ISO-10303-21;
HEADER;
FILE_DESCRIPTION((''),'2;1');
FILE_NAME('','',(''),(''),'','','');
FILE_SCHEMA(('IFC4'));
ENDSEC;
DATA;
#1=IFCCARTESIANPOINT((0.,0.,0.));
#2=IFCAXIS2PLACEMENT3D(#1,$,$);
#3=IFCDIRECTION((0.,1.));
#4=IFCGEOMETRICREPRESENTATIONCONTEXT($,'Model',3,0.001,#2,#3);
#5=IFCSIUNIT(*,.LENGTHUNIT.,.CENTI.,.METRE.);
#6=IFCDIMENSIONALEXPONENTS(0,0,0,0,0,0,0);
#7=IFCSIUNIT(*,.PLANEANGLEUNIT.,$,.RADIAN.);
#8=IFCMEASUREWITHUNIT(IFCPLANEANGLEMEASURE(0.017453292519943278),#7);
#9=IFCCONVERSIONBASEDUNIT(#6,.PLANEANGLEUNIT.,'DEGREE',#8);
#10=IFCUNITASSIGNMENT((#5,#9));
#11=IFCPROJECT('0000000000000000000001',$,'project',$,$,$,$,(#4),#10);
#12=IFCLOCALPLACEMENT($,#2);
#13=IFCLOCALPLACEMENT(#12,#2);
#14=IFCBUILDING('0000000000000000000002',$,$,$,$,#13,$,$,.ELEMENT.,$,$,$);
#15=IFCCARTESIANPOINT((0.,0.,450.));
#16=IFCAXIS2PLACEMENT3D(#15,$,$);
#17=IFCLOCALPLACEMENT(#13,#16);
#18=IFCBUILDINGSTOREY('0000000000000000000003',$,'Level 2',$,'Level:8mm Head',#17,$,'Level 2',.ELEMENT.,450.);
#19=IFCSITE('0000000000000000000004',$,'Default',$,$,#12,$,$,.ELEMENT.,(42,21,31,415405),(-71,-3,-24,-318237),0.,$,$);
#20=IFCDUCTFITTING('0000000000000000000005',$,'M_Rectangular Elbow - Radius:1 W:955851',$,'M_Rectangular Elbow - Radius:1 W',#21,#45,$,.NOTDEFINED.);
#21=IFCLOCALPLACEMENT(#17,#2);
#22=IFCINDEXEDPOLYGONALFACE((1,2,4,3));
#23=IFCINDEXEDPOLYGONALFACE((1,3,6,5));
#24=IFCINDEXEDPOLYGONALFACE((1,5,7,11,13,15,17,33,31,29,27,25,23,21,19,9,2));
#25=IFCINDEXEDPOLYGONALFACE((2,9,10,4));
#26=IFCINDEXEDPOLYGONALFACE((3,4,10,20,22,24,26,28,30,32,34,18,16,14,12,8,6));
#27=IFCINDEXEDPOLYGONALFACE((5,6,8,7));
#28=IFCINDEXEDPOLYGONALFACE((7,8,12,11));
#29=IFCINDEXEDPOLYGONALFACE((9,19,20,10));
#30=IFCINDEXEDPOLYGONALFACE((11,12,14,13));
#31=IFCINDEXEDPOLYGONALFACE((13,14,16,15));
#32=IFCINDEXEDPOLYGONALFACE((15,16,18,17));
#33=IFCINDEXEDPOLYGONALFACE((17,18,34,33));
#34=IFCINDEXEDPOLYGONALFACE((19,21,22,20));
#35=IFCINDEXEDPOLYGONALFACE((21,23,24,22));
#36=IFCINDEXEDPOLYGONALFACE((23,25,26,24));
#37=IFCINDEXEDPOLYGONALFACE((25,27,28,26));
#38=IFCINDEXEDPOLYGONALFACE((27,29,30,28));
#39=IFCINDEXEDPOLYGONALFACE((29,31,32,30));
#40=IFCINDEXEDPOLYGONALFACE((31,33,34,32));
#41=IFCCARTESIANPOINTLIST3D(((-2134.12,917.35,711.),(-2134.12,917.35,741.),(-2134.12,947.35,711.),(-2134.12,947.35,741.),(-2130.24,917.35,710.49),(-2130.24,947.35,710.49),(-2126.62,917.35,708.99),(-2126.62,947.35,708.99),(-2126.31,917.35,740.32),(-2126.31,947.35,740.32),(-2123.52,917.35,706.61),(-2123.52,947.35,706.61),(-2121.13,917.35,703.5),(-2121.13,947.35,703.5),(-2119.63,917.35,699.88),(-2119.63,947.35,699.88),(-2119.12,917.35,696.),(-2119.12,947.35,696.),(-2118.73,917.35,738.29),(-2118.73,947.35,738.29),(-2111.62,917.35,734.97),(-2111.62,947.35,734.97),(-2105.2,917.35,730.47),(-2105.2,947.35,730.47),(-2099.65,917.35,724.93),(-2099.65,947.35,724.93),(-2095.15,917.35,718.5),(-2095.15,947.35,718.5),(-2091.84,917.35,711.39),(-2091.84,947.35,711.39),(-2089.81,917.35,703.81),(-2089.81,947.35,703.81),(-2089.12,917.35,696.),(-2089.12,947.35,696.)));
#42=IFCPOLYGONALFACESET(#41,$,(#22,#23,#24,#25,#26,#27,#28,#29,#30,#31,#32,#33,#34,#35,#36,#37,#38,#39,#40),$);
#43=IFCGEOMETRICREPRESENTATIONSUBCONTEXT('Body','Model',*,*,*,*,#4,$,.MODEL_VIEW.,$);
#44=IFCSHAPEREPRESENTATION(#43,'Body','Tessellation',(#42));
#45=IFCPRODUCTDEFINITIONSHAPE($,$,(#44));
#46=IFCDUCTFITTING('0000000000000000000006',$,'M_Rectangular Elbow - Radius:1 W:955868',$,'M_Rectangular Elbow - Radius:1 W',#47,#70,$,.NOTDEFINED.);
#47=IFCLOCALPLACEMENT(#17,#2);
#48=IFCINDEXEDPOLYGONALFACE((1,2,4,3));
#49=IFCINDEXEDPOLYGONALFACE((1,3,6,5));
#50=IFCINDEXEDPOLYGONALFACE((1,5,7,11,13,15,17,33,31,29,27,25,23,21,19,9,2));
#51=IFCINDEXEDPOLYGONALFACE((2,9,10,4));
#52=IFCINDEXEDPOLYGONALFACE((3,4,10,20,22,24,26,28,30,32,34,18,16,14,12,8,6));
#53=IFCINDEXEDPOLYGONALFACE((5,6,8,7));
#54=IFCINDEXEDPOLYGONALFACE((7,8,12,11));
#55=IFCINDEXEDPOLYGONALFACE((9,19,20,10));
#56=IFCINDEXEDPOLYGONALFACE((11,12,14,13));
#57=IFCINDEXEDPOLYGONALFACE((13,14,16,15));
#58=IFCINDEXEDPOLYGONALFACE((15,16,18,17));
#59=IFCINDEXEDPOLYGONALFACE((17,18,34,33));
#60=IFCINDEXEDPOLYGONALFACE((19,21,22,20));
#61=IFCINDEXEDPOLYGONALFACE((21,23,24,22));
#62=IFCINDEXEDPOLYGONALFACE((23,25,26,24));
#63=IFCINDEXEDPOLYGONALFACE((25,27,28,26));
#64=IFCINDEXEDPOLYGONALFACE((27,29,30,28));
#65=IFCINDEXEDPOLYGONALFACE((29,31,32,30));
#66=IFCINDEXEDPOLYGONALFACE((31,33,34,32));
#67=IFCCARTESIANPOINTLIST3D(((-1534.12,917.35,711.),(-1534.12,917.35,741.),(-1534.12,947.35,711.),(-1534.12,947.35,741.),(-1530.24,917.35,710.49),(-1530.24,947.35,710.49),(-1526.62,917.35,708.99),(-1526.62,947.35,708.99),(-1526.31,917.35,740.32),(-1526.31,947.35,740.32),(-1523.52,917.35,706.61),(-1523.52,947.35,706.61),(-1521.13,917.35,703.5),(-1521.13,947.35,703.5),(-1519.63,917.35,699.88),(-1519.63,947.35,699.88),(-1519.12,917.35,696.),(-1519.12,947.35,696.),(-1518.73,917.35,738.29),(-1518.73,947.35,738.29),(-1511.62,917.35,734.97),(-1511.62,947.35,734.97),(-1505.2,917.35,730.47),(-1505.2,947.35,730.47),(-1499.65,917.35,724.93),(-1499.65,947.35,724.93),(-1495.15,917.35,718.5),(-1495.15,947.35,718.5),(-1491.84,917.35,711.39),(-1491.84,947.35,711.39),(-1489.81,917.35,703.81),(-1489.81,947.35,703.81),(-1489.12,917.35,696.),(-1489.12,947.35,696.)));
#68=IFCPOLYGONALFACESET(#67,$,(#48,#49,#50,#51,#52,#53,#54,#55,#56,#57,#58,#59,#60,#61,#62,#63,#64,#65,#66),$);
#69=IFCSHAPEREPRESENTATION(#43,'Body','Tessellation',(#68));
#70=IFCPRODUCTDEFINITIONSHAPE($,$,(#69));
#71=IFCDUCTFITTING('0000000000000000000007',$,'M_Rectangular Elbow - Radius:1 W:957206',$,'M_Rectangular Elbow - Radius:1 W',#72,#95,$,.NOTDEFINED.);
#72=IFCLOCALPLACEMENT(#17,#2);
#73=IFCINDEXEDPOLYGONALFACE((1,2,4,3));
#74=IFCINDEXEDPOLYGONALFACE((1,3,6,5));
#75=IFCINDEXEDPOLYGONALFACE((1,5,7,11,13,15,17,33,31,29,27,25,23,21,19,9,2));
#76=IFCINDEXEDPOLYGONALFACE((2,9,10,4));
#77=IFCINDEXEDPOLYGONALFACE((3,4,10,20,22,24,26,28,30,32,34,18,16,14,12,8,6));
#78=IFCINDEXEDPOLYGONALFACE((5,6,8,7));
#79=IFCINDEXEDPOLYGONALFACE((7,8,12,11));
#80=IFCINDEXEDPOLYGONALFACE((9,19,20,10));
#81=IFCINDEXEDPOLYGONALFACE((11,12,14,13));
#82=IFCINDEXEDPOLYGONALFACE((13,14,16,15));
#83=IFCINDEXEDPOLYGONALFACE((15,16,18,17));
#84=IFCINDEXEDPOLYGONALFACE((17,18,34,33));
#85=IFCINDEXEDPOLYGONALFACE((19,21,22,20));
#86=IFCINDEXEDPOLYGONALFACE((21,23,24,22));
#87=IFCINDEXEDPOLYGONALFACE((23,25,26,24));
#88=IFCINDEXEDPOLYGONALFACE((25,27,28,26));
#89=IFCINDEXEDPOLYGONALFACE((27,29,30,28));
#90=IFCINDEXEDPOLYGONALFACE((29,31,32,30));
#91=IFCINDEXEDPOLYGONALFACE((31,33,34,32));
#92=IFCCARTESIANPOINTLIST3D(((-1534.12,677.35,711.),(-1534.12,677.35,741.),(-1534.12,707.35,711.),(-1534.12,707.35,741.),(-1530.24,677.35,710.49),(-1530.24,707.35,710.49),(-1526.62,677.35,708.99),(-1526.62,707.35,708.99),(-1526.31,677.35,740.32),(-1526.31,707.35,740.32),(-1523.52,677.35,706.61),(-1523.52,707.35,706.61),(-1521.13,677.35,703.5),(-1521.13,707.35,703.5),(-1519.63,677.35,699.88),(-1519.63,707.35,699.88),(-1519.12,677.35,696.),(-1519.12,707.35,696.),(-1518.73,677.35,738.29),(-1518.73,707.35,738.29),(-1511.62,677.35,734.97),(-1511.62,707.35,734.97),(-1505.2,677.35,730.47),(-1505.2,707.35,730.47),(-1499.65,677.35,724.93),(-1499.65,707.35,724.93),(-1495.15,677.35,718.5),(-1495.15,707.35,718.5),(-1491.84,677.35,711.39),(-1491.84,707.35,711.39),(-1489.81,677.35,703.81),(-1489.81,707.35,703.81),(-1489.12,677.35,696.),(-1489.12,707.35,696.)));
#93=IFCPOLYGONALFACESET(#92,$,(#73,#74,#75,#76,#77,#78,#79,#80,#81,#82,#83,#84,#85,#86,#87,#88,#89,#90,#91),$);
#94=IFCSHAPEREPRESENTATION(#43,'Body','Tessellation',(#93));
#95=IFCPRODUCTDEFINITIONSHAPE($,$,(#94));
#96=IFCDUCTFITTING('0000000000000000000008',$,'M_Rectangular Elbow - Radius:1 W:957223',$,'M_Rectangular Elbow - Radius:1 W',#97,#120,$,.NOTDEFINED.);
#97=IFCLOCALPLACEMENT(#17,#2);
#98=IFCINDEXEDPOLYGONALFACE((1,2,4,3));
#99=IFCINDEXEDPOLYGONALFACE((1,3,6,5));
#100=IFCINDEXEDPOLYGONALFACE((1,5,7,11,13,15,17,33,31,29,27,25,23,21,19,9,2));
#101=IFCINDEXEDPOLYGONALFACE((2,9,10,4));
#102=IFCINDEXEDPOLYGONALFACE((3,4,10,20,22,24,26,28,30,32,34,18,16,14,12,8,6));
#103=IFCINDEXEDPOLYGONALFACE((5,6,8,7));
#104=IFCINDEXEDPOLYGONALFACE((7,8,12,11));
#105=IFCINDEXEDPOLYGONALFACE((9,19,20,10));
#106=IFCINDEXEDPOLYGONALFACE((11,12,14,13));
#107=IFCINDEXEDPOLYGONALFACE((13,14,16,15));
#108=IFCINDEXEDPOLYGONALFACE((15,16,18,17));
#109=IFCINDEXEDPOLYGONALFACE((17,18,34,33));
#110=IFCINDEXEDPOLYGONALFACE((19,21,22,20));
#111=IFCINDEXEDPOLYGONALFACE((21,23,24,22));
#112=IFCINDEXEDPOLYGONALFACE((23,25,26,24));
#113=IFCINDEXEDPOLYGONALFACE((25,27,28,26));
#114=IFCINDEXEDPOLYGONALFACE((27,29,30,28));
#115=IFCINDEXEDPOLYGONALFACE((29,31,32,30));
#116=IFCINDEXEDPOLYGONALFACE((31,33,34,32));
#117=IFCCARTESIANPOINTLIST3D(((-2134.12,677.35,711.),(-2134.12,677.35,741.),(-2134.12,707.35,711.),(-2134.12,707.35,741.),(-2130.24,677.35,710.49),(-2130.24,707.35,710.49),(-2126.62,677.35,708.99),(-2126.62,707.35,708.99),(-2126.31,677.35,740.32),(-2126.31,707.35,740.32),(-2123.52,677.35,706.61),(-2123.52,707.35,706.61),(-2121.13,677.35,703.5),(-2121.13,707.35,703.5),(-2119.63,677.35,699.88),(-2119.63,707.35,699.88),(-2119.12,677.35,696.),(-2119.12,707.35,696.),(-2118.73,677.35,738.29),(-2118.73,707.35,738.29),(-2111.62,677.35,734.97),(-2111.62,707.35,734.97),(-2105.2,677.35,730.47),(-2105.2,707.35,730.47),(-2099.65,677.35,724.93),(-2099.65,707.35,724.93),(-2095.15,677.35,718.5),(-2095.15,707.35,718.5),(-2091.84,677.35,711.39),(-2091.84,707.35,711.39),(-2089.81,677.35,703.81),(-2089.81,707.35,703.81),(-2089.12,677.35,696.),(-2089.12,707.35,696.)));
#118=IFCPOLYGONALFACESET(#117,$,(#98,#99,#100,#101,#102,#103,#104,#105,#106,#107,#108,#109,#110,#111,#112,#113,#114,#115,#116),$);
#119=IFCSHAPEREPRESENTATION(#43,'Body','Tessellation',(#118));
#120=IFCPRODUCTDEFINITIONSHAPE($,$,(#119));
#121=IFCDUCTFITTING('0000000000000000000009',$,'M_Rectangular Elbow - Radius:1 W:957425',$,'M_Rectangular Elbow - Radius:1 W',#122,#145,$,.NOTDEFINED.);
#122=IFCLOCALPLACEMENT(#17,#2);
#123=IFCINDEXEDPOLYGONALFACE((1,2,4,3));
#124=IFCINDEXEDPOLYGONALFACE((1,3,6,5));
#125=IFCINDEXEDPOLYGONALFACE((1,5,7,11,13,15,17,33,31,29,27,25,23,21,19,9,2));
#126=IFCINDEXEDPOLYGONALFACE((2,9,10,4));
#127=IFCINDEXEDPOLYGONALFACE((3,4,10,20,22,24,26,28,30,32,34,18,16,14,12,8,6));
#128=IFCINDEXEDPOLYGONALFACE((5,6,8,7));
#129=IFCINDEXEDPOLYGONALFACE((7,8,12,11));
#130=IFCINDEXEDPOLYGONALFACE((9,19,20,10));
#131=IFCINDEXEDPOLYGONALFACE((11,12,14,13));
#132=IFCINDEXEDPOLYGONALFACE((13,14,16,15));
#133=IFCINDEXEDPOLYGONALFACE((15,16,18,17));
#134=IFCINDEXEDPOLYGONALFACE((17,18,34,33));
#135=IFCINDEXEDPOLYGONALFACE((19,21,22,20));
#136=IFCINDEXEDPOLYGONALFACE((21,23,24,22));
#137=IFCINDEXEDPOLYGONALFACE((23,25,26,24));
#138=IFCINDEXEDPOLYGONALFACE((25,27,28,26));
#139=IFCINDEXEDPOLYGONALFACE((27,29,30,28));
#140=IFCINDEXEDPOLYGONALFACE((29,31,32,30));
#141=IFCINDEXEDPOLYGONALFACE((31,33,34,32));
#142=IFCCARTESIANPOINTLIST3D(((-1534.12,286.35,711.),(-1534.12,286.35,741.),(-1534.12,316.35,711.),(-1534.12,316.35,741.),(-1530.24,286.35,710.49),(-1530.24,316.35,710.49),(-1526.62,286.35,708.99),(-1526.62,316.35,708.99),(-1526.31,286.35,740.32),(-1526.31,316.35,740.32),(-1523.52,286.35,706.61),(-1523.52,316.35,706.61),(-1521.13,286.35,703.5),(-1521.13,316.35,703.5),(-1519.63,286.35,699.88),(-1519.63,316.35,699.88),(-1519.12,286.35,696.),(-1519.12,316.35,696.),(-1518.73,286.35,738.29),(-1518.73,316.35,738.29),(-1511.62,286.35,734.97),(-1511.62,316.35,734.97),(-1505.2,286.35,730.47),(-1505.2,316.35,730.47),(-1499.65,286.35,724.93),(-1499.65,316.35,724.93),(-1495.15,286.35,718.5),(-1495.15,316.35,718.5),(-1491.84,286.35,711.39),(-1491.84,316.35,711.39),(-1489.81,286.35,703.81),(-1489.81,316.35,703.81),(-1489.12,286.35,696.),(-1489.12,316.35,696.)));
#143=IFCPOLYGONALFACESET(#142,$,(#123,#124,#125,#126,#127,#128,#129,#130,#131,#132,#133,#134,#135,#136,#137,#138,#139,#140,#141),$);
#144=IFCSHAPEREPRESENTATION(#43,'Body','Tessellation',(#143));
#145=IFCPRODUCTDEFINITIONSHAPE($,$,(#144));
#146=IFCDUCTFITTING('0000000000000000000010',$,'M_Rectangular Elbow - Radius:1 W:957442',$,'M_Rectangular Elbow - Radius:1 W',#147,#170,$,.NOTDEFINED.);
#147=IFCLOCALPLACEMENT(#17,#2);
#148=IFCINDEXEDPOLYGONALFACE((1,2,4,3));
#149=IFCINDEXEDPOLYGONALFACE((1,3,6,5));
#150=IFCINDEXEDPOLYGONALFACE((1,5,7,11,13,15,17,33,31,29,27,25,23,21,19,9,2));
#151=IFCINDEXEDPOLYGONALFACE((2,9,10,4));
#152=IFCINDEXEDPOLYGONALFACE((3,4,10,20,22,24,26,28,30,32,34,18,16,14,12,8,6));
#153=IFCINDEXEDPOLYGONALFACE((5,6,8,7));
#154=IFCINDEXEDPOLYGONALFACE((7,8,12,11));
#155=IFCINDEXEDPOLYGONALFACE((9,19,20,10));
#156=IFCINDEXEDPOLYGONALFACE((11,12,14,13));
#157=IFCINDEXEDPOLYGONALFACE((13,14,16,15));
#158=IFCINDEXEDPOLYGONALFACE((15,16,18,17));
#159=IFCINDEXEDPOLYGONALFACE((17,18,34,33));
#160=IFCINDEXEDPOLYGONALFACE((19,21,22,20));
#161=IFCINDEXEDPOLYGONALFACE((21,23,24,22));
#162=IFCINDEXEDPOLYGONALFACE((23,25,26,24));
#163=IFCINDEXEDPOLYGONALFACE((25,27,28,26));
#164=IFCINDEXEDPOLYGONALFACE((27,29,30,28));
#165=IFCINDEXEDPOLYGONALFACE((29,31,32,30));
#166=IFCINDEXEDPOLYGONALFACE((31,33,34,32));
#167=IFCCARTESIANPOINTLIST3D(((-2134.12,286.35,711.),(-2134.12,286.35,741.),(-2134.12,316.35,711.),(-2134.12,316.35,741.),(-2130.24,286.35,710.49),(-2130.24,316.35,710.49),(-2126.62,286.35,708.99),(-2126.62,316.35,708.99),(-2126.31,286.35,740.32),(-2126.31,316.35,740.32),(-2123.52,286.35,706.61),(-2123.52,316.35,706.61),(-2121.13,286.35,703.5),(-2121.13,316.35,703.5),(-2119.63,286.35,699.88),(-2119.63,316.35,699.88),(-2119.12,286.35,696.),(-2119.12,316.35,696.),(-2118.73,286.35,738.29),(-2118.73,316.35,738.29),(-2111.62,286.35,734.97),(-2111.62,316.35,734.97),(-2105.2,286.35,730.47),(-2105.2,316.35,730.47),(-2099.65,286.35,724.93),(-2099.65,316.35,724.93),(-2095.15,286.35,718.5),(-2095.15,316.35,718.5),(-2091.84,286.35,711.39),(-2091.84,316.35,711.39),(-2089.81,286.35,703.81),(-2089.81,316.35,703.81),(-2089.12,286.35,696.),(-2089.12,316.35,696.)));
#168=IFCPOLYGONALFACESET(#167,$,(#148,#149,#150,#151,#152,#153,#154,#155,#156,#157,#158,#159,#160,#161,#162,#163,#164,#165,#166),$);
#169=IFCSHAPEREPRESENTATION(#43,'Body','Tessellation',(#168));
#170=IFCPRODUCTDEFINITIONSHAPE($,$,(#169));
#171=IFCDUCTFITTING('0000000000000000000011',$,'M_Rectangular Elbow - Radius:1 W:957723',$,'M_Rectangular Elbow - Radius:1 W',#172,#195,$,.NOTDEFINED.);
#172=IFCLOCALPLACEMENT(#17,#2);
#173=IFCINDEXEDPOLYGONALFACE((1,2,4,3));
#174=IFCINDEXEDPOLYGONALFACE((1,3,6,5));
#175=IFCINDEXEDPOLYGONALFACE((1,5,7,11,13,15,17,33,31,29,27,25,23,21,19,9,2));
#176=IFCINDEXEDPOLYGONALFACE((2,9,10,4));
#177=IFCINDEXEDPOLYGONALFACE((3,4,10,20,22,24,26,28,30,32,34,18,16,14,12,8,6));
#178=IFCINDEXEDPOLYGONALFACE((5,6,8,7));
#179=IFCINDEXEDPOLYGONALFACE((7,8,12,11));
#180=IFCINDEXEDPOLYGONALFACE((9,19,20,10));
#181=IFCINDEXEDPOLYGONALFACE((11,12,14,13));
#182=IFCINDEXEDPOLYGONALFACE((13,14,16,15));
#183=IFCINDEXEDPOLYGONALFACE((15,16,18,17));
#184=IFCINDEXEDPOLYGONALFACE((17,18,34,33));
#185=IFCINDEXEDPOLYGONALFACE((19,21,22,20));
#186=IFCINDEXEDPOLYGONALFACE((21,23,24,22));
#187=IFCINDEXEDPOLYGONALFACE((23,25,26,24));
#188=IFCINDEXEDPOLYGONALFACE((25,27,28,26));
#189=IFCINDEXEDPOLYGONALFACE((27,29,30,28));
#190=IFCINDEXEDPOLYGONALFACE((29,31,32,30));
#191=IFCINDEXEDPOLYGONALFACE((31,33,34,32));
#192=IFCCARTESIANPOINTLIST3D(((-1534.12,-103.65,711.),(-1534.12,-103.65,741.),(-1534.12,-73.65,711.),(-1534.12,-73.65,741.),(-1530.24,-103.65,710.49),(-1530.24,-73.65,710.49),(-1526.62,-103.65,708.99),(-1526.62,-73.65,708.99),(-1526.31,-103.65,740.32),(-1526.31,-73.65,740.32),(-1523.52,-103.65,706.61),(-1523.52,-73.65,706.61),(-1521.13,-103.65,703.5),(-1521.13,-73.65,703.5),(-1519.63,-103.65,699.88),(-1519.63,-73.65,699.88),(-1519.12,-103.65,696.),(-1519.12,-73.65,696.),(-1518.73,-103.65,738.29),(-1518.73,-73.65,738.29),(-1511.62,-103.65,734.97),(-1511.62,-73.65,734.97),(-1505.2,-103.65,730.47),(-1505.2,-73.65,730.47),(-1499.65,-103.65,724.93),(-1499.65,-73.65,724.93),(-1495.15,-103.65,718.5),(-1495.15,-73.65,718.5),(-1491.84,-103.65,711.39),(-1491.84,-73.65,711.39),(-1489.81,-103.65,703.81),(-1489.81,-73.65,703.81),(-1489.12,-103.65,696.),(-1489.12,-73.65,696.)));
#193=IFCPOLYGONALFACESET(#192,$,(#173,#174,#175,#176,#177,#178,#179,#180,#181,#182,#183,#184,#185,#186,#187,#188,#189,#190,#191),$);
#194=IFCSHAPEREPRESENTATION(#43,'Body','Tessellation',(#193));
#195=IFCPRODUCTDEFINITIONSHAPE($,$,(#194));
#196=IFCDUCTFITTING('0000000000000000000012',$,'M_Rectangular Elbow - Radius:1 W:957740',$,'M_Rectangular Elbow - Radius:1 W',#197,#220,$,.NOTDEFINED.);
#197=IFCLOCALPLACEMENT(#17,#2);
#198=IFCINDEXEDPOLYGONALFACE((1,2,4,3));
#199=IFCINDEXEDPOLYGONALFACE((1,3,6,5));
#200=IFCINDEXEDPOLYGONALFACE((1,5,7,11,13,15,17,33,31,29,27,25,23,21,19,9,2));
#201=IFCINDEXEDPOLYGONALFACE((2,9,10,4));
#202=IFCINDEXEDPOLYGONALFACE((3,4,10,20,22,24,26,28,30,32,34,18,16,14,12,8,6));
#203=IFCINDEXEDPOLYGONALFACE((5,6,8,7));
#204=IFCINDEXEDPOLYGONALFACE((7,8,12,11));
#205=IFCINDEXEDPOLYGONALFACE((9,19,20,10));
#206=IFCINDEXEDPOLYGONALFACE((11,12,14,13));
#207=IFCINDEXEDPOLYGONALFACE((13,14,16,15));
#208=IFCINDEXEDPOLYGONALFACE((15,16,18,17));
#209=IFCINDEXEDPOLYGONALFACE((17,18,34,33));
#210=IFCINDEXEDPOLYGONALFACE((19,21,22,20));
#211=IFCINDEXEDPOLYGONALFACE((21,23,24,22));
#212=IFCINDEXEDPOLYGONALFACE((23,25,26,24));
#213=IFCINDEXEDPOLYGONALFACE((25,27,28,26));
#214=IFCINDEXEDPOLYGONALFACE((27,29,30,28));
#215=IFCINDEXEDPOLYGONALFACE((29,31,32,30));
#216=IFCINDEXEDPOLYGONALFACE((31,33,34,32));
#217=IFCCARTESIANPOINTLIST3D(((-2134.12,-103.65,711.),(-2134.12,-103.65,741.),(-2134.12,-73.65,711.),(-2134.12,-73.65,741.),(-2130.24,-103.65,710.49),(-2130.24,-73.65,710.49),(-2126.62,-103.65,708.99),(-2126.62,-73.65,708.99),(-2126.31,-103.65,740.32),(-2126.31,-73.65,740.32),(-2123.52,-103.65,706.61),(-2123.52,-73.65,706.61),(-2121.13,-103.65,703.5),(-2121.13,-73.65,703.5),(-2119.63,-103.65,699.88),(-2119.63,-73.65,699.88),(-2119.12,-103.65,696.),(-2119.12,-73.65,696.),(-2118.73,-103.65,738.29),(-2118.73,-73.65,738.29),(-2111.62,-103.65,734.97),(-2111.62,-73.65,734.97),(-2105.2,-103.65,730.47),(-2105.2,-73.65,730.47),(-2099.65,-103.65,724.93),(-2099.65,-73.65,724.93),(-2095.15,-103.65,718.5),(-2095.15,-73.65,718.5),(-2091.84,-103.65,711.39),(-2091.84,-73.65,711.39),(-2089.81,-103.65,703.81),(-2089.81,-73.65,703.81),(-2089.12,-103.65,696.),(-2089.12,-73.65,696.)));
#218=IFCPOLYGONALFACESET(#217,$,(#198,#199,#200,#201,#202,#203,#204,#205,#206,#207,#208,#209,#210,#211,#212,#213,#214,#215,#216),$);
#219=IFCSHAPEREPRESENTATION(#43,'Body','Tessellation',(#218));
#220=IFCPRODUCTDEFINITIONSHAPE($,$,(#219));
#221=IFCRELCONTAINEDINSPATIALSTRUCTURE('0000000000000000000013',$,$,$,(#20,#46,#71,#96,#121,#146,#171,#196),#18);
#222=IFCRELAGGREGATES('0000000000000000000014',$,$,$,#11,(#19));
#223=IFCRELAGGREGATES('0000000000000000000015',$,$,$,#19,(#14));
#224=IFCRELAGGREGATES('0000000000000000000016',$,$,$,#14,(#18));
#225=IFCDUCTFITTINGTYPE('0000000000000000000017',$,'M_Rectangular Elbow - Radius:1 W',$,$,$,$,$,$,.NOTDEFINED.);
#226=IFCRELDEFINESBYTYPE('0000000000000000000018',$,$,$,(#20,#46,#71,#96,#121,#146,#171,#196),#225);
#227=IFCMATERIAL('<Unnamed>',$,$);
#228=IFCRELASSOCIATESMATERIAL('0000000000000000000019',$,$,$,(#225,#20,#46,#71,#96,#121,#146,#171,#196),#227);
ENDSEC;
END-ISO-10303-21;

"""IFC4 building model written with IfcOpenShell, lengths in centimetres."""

from ifc_helpers import new_model, entity, si_unit, converted_unit, direction, frame, origin, place, context, subcontext, project, spatial, line, arc, indexed_curve, outline, extrude, source, transform, mapped, material, type_object, type_shapes, element, save


model = new_model("IFC4")

# Units and contexts
model_context = context("Model", 3, precision=0.001, world=origin(), true_north=direction((0.0, 1.0)))
body_context = subcontext(model_context, "Body", "Model", "MODEL_VIEW")
ifc_project = project(units=[si_unit("LENGTHUNIT", "METRE", prefix="CENTI"), converted_unit("PLANEANGLEUNIT", "DEGREE", entity("IfcPlaneAngleMeasure", 0.017453292519943278), si_unit("PLANEANGLEUNIT", "RADIAN"), dimensions=[0, 0, 0, 0, 0, 0, 0])], contexts=[model_context])

# Site, building, storey
site_placement = place(None, origin())
site = spatial("IfcSite", under=ifc_project, at=site_placement, Name="Default", CompositionType="ELEMENT", RefLatitude=(42, 21, 31, 415405), RefLongitude=(-71, -3, -24, -318237), RefElevation=0.0)
building_placement = place(site_placement, origin())
building = spatial("IfcBuilding", under=site, at=building_placement, CompositionType="ELEMENT")
storey_placement = place(building_placement, frame((0.0, 0.0, 450.0)))
storey = spatial("IfcBuildingStorey", under=building, at=storey_placement, Name="Level 2", ObjectType="Level:8mm Head", LongName="Level 2", CompositionType="ELEMENT", Elevation=450.0)

# Duct fittings
ifc_material = material(Name="<Unnamed>")
duct_fitting_type_1 = type_object("IfcDuctFittingType", Name="M_Rectangular Elbow - Radius:1 W", PredefinedType="NOTDEFINED", material=ifc_material)
shared_shape_1 = source(origin(), body_context, "Body", "SweptSolid", [
    extrude(outline(indexed_curve([(-30.0, -15.0), (0.0, -15.0), (4.39, -4.39), (15.0, 0.0), (15.0, 30.0), (-16.82, 16.82)], segments=[line(1, 2), arc(2, 3, 4), line(4, 5), arc(5, 6, 1)], self_intersect=False)), frame((-15.0, 15.0, -15.0), z_axis=(0.0, 0.0, 1.0), x_axis=(-1.0, 0.0, 0.0)), (0.0, 0.0, 1.0), 30.0),
])
type_shapes(duct_fitting_type_1, [shared_shape_1])
for number, where, z_axis, x_axis, name in (
    (1, (-2104.12, 932.35, 726.0), (0.0, 1.0, 0.0), (1.0, 0.0, 0.0), "M_Rectangular Elbow - Radius:1 W:955851"),
    (2, (-1504.12, 932.35, 726.0), (0.0, 1.0, 0.0), (1.0, 0.0, 0.0), "M_Rectangular Elbow - Radius:1 W:955868"),
    (3, (-1504.12, 692.35, 726.0), (0.0, 1.0, 0.0), (1.0, 0.0, 0.0), "M_Rectangular Elbow - Radius:1 W:957206"),
    (4, (-2104.12, 692.35, 726.0), (0.0, 1.0, 0.0), (1.0, 0.0, 0.0), "M_Rectangular Elbow - Radius:1 W:957223"),
    (5, (-1504.12, 301.35, 726.0), (0.0, 1.0, 0.0), (1.0, 0.0, 0.0), "M_Rectangular Elbow - Radius:1 W:957425"),
    (6, (-2104.12, 301.35, 726.0), (0.0, 1.0, 0.0), (1.0, 0.0, 0.0), "M_Rectangular Elbow - Radius:1 W:957442"),
    (7, (-1504.12, -88.65, 726.0), (0.0, 1.0, 0.0), (1.0, 0.0, 0.0), "M_Rectangular Elbow - Radius:1 W:957723"),
    (8, (-2104.12, -88.65, 726.0), (0.0, 1.0, 0.0), (1.0, 0.0, 0.0), "M_Rectangular Elbow - Radius:1 W:957740"),
):
    element("IfcDuctFitting", number, at=place(storey_placement, frame(where, z_axis=z_axis, x_axis=x_axis)), inside=storey, type_object=duct_fitting_type_1, material=ifc_material, Name=name, ObjectType="M_Rectangular Elbow - Radius:1 W", PredefinedType="NOTDEFINED", context=body_context, shape_type="MappedRepresentation", body=[
        mapped(shared_shape_1, transform((0.0, 0.0, 0.0), scale=1.0)),
    ])

save(model, "model.ifc")
